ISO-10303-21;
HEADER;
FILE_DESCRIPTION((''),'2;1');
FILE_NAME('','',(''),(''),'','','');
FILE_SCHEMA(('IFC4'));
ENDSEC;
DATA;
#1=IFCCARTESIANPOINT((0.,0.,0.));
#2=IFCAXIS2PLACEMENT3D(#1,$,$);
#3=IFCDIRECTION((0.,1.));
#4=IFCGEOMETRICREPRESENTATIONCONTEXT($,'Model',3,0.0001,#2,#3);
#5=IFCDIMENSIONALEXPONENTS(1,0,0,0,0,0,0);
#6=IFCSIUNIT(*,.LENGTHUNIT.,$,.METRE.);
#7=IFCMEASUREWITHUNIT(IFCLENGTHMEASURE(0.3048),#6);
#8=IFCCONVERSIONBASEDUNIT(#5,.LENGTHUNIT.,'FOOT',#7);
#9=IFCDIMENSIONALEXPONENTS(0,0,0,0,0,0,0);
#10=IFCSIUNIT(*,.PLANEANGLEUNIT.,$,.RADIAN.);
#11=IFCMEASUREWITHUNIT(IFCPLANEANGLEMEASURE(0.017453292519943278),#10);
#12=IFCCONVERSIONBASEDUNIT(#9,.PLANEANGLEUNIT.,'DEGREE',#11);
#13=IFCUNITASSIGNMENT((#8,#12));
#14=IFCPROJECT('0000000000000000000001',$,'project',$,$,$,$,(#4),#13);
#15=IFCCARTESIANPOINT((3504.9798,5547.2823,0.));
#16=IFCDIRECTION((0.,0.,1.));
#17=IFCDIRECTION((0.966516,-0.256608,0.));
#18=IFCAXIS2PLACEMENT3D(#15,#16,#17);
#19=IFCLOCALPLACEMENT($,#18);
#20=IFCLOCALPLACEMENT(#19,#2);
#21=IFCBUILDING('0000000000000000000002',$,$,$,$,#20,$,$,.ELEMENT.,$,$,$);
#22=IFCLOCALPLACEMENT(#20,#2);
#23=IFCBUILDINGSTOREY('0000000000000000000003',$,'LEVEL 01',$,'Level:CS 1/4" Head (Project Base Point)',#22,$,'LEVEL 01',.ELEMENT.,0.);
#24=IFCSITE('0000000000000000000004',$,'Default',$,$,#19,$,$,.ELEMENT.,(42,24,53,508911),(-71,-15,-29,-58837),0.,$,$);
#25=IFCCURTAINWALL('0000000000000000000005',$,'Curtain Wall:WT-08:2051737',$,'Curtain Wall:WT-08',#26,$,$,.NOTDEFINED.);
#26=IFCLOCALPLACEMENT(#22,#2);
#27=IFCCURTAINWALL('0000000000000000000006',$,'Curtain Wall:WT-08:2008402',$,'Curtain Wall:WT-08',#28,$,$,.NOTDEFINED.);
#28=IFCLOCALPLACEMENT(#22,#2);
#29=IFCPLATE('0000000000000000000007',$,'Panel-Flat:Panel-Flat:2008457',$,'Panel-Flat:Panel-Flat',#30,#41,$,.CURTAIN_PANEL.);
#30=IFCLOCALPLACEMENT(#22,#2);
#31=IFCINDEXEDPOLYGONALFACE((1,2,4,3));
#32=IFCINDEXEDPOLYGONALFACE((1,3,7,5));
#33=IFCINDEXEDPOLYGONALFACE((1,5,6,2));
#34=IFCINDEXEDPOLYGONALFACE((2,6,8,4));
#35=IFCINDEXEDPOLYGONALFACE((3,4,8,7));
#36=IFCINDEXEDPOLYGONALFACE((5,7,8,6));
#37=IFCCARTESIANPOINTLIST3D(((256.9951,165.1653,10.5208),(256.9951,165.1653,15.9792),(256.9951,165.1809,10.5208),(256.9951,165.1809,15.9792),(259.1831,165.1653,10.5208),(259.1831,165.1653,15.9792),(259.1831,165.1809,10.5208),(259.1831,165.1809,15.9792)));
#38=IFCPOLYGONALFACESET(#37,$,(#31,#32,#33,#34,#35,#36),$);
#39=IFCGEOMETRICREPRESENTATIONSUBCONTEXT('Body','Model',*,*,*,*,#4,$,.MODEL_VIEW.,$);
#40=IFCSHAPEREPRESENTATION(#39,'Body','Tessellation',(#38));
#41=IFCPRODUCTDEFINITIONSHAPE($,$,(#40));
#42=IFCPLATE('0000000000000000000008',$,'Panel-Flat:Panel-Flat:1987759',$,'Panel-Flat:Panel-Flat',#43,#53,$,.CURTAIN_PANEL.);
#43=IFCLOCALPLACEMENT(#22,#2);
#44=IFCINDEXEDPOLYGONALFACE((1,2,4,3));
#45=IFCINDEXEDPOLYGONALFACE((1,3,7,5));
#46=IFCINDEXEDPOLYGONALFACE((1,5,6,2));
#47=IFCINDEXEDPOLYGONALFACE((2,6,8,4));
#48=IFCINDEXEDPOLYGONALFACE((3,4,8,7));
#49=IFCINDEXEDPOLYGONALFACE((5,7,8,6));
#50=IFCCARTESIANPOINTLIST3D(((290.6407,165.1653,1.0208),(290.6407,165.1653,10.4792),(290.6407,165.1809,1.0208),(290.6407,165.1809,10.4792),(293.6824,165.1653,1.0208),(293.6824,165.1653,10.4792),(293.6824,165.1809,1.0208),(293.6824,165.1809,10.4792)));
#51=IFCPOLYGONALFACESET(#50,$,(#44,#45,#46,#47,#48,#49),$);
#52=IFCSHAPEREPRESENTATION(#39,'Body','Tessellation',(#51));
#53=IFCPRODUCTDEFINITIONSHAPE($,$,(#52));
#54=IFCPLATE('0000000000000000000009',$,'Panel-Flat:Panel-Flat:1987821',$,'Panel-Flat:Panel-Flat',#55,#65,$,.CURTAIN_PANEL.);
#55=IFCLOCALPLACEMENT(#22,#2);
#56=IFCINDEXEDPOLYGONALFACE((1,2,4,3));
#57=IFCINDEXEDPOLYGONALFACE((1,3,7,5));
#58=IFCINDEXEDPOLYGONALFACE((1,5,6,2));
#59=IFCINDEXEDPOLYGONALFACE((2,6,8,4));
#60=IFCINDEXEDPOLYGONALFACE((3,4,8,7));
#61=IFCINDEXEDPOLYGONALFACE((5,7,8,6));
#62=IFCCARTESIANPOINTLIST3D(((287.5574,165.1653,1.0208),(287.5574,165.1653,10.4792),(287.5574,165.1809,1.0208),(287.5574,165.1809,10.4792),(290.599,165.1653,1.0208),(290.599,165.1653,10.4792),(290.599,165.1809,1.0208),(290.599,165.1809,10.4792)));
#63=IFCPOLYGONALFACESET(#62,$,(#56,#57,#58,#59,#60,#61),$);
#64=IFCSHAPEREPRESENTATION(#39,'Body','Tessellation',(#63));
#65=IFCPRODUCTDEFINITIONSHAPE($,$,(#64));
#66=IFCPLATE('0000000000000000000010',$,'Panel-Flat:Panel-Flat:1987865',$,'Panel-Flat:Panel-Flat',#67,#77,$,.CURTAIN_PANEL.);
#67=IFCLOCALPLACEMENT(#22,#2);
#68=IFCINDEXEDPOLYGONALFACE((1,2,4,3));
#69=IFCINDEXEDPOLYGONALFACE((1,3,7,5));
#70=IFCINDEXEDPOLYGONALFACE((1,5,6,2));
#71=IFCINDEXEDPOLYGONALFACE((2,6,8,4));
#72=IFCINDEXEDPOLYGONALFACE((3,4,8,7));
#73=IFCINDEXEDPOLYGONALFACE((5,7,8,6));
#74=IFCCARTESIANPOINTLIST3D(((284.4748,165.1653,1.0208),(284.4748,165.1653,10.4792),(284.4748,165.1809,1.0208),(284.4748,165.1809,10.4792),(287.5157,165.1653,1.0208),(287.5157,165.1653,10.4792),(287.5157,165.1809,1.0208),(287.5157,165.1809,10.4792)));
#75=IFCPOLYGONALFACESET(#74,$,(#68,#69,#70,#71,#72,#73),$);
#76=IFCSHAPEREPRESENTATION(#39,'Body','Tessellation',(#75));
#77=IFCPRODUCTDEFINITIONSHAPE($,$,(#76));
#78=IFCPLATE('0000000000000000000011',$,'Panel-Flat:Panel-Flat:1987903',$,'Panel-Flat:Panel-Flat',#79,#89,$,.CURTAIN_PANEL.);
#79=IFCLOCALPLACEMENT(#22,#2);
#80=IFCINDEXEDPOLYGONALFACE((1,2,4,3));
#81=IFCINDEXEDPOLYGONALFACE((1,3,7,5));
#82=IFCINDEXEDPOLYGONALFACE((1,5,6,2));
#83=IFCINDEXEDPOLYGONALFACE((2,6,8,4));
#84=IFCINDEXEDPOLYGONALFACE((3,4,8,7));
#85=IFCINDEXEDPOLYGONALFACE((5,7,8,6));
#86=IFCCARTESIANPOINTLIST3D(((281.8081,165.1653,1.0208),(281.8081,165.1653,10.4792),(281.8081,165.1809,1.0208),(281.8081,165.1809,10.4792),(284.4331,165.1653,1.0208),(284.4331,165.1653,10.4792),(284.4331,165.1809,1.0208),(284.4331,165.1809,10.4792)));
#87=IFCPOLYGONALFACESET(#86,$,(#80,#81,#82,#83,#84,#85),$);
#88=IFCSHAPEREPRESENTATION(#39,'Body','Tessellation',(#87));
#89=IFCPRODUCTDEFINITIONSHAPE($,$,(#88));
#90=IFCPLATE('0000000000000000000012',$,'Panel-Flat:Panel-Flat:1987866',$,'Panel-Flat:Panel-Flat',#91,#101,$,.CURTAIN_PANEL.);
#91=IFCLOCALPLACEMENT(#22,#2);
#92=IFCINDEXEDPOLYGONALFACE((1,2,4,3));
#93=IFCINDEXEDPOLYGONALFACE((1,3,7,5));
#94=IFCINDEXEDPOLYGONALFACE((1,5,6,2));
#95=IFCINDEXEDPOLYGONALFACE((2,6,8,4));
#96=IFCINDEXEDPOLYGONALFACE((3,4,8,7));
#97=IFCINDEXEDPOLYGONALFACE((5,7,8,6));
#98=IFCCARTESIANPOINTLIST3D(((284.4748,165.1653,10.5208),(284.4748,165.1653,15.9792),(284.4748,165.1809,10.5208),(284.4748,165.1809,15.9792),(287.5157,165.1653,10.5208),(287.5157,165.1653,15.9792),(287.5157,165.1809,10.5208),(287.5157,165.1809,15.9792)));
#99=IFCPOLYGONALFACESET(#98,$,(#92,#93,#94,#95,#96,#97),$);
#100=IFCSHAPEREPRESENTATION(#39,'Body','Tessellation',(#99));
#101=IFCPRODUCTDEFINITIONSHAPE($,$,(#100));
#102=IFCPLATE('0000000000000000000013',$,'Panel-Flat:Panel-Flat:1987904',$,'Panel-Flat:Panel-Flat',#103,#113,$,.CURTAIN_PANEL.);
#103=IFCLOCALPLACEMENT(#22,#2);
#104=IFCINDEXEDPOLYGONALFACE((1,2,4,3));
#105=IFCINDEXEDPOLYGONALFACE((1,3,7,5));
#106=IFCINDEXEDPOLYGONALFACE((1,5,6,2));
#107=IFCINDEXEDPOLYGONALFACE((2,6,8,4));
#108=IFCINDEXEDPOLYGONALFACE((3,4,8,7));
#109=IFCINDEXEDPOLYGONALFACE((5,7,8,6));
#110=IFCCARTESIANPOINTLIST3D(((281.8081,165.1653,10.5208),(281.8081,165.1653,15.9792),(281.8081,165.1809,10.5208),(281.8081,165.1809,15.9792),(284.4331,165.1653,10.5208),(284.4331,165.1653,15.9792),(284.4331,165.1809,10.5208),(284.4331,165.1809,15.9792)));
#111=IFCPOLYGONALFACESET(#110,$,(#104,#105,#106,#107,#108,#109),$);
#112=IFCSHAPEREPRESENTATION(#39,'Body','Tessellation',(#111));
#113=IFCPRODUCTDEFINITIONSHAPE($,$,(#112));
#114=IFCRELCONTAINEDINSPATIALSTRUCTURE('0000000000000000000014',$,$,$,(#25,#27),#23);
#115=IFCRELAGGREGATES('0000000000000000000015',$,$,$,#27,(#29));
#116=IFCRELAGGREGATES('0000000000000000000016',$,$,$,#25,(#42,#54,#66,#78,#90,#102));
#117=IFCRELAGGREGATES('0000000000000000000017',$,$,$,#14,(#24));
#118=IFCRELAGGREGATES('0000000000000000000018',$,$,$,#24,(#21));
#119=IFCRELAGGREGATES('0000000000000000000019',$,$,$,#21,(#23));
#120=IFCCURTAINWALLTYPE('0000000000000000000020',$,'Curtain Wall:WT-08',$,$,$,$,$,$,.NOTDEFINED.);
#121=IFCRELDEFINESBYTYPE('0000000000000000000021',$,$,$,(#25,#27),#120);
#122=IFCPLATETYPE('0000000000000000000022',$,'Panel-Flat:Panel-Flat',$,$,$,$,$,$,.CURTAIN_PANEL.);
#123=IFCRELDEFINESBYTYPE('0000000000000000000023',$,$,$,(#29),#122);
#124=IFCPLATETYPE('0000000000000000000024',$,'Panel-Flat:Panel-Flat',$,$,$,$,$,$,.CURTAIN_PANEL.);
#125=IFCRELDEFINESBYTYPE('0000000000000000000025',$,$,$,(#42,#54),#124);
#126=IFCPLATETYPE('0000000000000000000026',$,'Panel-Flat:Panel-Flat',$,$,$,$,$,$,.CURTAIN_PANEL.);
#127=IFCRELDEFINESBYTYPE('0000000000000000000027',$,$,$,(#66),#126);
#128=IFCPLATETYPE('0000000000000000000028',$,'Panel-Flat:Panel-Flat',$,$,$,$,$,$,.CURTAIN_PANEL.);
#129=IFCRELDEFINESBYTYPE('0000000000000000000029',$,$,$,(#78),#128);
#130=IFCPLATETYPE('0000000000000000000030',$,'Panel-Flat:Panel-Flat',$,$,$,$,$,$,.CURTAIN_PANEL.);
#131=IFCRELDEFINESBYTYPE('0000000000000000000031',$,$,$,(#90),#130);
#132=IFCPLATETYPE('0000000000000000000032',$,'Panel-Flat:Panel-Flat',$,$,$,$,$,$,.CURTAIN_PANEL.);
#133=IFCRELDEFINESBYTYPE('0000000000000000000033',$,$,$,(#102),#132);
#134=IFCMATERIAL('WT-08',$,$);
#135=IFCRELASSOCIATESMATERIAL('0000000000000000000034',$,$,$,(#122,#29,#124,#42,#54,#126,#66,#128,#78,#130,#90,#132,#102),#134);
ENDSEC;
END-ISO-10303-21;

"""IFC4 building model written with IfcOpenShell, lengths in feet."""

from ifc_helpers import new_model, entity, si_unit, converted_unit, direction, frame, origin, place, context, subcontext, project, spatial, indexed_curve, outline, extrude, source, transform, mapped, material, type_object, type_shapes, element, aggregate, save


model = new_model("IFC4")

# Units and contexts
model_context = context("Model", 3, precision=0.0001, world=origin(), true_north=direction((0.0, 1.0)))
body_context = subcontext(model_context, "Body", "Model", "MODEL_VIEW")
ifc_project = project(units=[converted_unit("LENGTHUNIT", "FOOT", entity("IfcLengthMeasure", 0.3048), si_unit("LENGTHUNIT", "METRE"), dimensions=[1, 0, 0, 0, 0, 0, 0]), converted_unit("PLANEANGLEUNIT", "DEGREE", entity("IfcPlaneAngleMeasure", 0.017453292519943278), si_unit("PLANEANGLEUNIT", "RADIAN"), dimensions=[0, 0, 0, 0, 0, 0, 0])], contexts=[model_context])

# Site, building, storey
site_placement = place(None, frame((3504.9798, 5547.2823, 0.0), z_axis=(0.0, 0.0, 1.0), x_axis=(0.966516, -0.256608, 0.0)))
site = spatial("IfcSite", under=ifc_project, at=site_placement, Name="Default", CompositionType="ELEMENT", RefLatitude=(42, 24, 53, 508911), RefLongitude=(-71, -15, -29, -58837), RefElevation=0.0)
building_placement = place(site_placement, origin())
building = spatial("IfcBuilding", under=site, at=building_placement, CompositionType="ELEMENT")
storey_placement = place(building_placement, origin())
storey = spatial("IfcBuildingStorey", under=building, at=storey_placement, Name="LEVEL 01", ObjectType="Level:CS 1/4\" Head (Project Base Point)", LongName="LEVEL 01", CompositionType="ELEMENT", Elevation=0.0)

# Curtain wall
curtain_wall_type_1 = type_object("IfcCurtainWallType", Name="Curtain Wall:WT-08", PredefinedType="NOTDEFINED")
curtain_wall_1_placement = place(storey_placement, origin())
curtain_wall_1 = element("IfcCurtainWall", 1, at=curtain_wall_1_placement, inside=storey, type_object=curtain_wall_type_1, Name="Curtain Wall:WT-08:2051737", ObjectType="Curtain Wall:WT-08", PredefinedType="NOTDEFINED")
ifc_material_1 = material(Name="WT-08")

# Curtain wall, plate
curtain_wall_2_placement = place(storey_placement, origin())
curtain_wall_2 = element("IfcCurtainWall", 2, at=curtain_wall_2_placement, inside=storey, type_object=curtain_wall_type_1, Name="Curtain Wall:WT-08:2008402", ObjectType="Curtain Wall:WT-08", PredefinedType="NOTDEFINED")
plate_type_1 = type_object("IfcPlateType", Name="Panel-Flat:Panel-Flat", PredefinedType="CURTAIN_PANEL", material=ifc_material_1)
shared_shape_1 = source(origin(), body_context, "Body", "SweptSolid", [
    extrude(outline(indexed_curve([(-0.0078, -1.094), (0.0078, -1.094), (0.0078, 1.094), (-0.0078, 1.094), (-0.0078, -1.094)], self_intersect=False)), frame((1.094, 0.0078, 0.0), z_axis=(0.0, 0.0, 1.0), x_axis=(0.0, -1.0, 0.0)), (0.0, 0.0, 1.0), 5.4583),
])
type_shapes(plate_type_1, [shared_shape_1])
plate_1_placement = place(curtain_wall_2_placement, frame((259.1831, 165.1809, 10.5208), z_axis=(0.0, 0.0, 1.0), x_axis=(-1.0, 0.0, 0.0)))
plate_1 = element("IfcPlate", 3, at=plate_1_placement, type_object=plate_type_1, material=ifc_material_1, Name="Panel-Flat:Panel-Flat:2008457", ObjectType="Panel-Flat:Panel-Flat", PredefinedType="CURTAIN_PANEL", context=body_context, shape_type="MappedRepresentation", body=[
    mapped(shared_shape_1, transform((0.0, 0.0, 0.0), scale=1.0)),
])
aggregate(curtain_wall_2, [plate_1])

# Plates
plate_type_2 = type_object("IfcPlateType", Name="Panel-Flat:Panel-Flat", PredefinedType="CURTAIN_PANEL", material=ifc_material_1)
shared_shape_2 = source(origin(), body_context, "Body", "SweptSolid", [
    extrude(outline(indexed_curve([(-0.0078, -1.5208), (0.0078, -1.5208), (0.0078, 1.5208), (-0.0078, 1.5208), (-0.0078, -1.5208)], self_intersect=False)), frame((1.5208, 0.0078, 0.0), z_axis=(0.0, 0.0, 1.0), x_axis=(0.0, -1.0, 0.0)), (0.0, 0.0, 1.0), 9.4583),
])
type_shapes(plate_type_2, [shared_shape_2])
plate_2_placement = place(curtain_wall_1_placement, frame((293.6824, 165.1809, 1.0208), z_axis=(0.0, 0.0, 1.0), x_axis=(-1.0, 0.0, 0.0)))
plate_2 = element("IfcPlate", 4, at=plate_2_placement, type_object=plate_type_2, material=ifc_material_1, Name="Panel-Flat:Panel-Flat:1987759", ObjectType="Panel-Flat:Panel-Flat", PredefinedType="CURTAIN_PANEL", context=body_context, shape_type="MappedRepresentation", body=[
    mapped(shared_shape_2, transform((0.0, 0.0, 0.0), scale=1.0)),
])
plate_3_placement = place(curtain_wall_1_placement, frame((290.599, 165.1809, 1.0208), z_axis=(0.0, 0.0, 1.0), x_axis=(-1.0, 0.0, 0.0)))
plate_3 = element("IfcPlate", 5, at=plate_3_placement, type_object=plate_type_2, material=ifc_material_1, Name="Panel-Flat:Panel-Flat:1987821", ObjectType="Panel-Flat:Panel-Flat", PredefinedType="CURTAIN_PANEL", context=body_context, shape_type="MappedRepresentation", body=[
    mapped(shared_shape_2, transform((0.0, 0.0, 0.0), scale=1.0)),
])
plate_type_3 = type_object("IfcPlateType", Name="Panel-Flat:Panel-Flat", PredefinedType="CURTAIN_PANEL", material=ifc_material_1)
shared_shape_3 = source(origin(), body_context, "Body", "SweptSolid", [
    extrude(outline(indexed_curve([(-0.0078, -1.5205), (0.0078, -1.5205), (0.0078, 1.5205), (-0.0078, 1.5205), (-0.0078, -1.5205)], self_intersect=False)), frame((1.5205, 0.0078, 0.0), z_axis=(0.0, 0.0, 1.0), x_axis=(0.0, -1.0, 0.0)), (0.0, 0.0, 1.0), 9.4583),
])
type_shapes(plate_type_3, [shared_shape_3])
plate_4_placement = place(curtain_wall_1_placement, frame((287.5157, 165.1809, 1.0208), z_axis=(0.0, 0.0, 1.0), x_axis=(-1.0, 0.0, 0.0)))
plate_4 = element("IfcPlate", 6, at=plate_4_placement, type_object=plate_type_3, material=ifc_material_1, Name="Panel-Flat:Panel-Flat:1987865", ObjectType="Panel-Flat:Panel-Flat", PredefinedType="CURTAIN_PANEL", context=body_context, shape_type="MappedRepresentation", body=[
    mapped(shared_shape_3, transform((0.0, 0.0, 0.0), scale=1.0)),
])
plate_type_4 = type_object("IfcPlateType", Name="Panel-Flat:Panel-Flat", PredefinedType="CURTAIN_PANEL", material=ifc_material_1)
shared_shape_4 = source(origin(), body_context, "Body", "SweptSolid", [
    extrude(outline(indexed_curve([(-0.0078, -1.3125), (0.0078, -1.3125), (0.0078, 1.3125), (-0.0078, 1.3125), (-0.0078, -1.3125)], self_intersect=False)), frame((1.3125, 0.0078, 0.0), z_axis=(0.0, 0.0, 1.0), x_axis=(0.0, -1.0, 0.0)), (0.0, 0.0, 1.0), 9.4583),
])
type_shapes(plate_type_4, [shared_shape_4])
plate_5_placement = place(curtain_wall_1_placement, frame((284.4331, 165.1809, 1.0208), z_axis=(0.0, 0.0, 1.0), x_axis=(-1.0, 0.0, 0.0)))
plate_5 = element("IfcPlate", 7, at=plate_5_placement, type_object=plate_type_4, material=ifc_material_1, Name="Panel-Flat:Panel-Flat:1987903", ObjectType="Panel-Flat:Panel-Flat", PredefinedType="CURTAIN_PANEL", context=body_context, shape_type="MappedRepresentation", body=[
    mapped(shared_shape_4, transform((0.0, 0.0, 0.0), scale=1.0)),
])
plate_type_5 = type_object("IfcPlateType", Name="Panel-Flat:Panel-Flat", PredefinedType="CURTAIN_PANEL", material=ifc_material_1)
shared_shape_5 = source(origin(), body_context, "Body", "SweptSolid", [
    extrude(outline(indexed_curve([(-0.0078, -1.5205), (0.0078, -1.5205), (0.0078, 1.5205), (-0.0078, 1.5205), (-0.0078, -1.5205)], self_intersect=False)), frame((1.5205, 0.0078, 0.0), z_axis=(0.0, 0.0, 1.0), x_axis=(0.0, -1.0, 0.0)), (0.0, 0.0, 1.0), 5.4583),
])
type_shapes(plate_type_5, [shared_shape_5])
plate_6_placement = place(curtain_wall_1_placement, frame((287.5157, 165.1809, 10.5208), z_axis=(0.0, 0.0, 1.0), x_axis=(-1.0, 0.0, 0.0)))
plate_6 = element("IfcPlate", 8, at=plate_6_placement, type_object=plate_type_5, material=ifc_material_1, Name="Panel-Flat:Panel-Flat:1987866", ObjectType="Panel-Flat:Panel-Flat", PredefinedType="CURTAIN_PANEL", context=body_context, shape_type="MappedRepresentation", body=[
    mapped(shared_shape_5, transform((0.0, 0.0, 0.0), scale=1.0)),
])
plate_type_6 = type_object("IfcPlateType", Name="Panel-Flat:Panel-Flat", PredefinedType="CURTAIN_PANEL", material=ifc_material_1)
shared_shape_6 = source(origin(), body_context, "Body", "SweptSolid", [
    extrude(outline(indexed_curve([(-0.0078, -1.3125), (0.0078, -1.3125), (0.0078, 1.3125), (-0.0078, 1.3125), (-0.0078, -1.3125)], self_intersect=False)), frame((1.3125, 0.0078, 0.0), z_axis=(0.0, 0.0, 1.0), x_axis=(0.0, -1.0, 0.0)), (0.0, 0.0, 1.0), 5.4583),
])
type_shapes(plate_type_6, [shared_shape_6])
plate_7_placement = place(curtain_wall_1_placement, frame((284.4331, 165.1809, 10.5208), z_axis=(0.0, 0.0, 1.0), x_axis=(-1.0, 0.0, 0.0)))
plate_7 = element("IfcPlate", 9, at=plate_7_placement, type_object=plate_type_6, material=ifc_material_1, Name="Panel-Flat:Panel-Flat:1987904", ObjectType="Panel-Flat:Panel-Flat", PredefinedType="CURTAIN_PANEL", context=body_context, shape_type="MappedRepresentation", body=[
    mapped(shared_shape_6, transform((0.0, 0.0, 0.0), scale=1.0)),
])
aggregate(curtain_wall_1, [plate_2, plate_3, plate_4, plate_5, plate_6, plate_7])

save(model, "model.ifc")
